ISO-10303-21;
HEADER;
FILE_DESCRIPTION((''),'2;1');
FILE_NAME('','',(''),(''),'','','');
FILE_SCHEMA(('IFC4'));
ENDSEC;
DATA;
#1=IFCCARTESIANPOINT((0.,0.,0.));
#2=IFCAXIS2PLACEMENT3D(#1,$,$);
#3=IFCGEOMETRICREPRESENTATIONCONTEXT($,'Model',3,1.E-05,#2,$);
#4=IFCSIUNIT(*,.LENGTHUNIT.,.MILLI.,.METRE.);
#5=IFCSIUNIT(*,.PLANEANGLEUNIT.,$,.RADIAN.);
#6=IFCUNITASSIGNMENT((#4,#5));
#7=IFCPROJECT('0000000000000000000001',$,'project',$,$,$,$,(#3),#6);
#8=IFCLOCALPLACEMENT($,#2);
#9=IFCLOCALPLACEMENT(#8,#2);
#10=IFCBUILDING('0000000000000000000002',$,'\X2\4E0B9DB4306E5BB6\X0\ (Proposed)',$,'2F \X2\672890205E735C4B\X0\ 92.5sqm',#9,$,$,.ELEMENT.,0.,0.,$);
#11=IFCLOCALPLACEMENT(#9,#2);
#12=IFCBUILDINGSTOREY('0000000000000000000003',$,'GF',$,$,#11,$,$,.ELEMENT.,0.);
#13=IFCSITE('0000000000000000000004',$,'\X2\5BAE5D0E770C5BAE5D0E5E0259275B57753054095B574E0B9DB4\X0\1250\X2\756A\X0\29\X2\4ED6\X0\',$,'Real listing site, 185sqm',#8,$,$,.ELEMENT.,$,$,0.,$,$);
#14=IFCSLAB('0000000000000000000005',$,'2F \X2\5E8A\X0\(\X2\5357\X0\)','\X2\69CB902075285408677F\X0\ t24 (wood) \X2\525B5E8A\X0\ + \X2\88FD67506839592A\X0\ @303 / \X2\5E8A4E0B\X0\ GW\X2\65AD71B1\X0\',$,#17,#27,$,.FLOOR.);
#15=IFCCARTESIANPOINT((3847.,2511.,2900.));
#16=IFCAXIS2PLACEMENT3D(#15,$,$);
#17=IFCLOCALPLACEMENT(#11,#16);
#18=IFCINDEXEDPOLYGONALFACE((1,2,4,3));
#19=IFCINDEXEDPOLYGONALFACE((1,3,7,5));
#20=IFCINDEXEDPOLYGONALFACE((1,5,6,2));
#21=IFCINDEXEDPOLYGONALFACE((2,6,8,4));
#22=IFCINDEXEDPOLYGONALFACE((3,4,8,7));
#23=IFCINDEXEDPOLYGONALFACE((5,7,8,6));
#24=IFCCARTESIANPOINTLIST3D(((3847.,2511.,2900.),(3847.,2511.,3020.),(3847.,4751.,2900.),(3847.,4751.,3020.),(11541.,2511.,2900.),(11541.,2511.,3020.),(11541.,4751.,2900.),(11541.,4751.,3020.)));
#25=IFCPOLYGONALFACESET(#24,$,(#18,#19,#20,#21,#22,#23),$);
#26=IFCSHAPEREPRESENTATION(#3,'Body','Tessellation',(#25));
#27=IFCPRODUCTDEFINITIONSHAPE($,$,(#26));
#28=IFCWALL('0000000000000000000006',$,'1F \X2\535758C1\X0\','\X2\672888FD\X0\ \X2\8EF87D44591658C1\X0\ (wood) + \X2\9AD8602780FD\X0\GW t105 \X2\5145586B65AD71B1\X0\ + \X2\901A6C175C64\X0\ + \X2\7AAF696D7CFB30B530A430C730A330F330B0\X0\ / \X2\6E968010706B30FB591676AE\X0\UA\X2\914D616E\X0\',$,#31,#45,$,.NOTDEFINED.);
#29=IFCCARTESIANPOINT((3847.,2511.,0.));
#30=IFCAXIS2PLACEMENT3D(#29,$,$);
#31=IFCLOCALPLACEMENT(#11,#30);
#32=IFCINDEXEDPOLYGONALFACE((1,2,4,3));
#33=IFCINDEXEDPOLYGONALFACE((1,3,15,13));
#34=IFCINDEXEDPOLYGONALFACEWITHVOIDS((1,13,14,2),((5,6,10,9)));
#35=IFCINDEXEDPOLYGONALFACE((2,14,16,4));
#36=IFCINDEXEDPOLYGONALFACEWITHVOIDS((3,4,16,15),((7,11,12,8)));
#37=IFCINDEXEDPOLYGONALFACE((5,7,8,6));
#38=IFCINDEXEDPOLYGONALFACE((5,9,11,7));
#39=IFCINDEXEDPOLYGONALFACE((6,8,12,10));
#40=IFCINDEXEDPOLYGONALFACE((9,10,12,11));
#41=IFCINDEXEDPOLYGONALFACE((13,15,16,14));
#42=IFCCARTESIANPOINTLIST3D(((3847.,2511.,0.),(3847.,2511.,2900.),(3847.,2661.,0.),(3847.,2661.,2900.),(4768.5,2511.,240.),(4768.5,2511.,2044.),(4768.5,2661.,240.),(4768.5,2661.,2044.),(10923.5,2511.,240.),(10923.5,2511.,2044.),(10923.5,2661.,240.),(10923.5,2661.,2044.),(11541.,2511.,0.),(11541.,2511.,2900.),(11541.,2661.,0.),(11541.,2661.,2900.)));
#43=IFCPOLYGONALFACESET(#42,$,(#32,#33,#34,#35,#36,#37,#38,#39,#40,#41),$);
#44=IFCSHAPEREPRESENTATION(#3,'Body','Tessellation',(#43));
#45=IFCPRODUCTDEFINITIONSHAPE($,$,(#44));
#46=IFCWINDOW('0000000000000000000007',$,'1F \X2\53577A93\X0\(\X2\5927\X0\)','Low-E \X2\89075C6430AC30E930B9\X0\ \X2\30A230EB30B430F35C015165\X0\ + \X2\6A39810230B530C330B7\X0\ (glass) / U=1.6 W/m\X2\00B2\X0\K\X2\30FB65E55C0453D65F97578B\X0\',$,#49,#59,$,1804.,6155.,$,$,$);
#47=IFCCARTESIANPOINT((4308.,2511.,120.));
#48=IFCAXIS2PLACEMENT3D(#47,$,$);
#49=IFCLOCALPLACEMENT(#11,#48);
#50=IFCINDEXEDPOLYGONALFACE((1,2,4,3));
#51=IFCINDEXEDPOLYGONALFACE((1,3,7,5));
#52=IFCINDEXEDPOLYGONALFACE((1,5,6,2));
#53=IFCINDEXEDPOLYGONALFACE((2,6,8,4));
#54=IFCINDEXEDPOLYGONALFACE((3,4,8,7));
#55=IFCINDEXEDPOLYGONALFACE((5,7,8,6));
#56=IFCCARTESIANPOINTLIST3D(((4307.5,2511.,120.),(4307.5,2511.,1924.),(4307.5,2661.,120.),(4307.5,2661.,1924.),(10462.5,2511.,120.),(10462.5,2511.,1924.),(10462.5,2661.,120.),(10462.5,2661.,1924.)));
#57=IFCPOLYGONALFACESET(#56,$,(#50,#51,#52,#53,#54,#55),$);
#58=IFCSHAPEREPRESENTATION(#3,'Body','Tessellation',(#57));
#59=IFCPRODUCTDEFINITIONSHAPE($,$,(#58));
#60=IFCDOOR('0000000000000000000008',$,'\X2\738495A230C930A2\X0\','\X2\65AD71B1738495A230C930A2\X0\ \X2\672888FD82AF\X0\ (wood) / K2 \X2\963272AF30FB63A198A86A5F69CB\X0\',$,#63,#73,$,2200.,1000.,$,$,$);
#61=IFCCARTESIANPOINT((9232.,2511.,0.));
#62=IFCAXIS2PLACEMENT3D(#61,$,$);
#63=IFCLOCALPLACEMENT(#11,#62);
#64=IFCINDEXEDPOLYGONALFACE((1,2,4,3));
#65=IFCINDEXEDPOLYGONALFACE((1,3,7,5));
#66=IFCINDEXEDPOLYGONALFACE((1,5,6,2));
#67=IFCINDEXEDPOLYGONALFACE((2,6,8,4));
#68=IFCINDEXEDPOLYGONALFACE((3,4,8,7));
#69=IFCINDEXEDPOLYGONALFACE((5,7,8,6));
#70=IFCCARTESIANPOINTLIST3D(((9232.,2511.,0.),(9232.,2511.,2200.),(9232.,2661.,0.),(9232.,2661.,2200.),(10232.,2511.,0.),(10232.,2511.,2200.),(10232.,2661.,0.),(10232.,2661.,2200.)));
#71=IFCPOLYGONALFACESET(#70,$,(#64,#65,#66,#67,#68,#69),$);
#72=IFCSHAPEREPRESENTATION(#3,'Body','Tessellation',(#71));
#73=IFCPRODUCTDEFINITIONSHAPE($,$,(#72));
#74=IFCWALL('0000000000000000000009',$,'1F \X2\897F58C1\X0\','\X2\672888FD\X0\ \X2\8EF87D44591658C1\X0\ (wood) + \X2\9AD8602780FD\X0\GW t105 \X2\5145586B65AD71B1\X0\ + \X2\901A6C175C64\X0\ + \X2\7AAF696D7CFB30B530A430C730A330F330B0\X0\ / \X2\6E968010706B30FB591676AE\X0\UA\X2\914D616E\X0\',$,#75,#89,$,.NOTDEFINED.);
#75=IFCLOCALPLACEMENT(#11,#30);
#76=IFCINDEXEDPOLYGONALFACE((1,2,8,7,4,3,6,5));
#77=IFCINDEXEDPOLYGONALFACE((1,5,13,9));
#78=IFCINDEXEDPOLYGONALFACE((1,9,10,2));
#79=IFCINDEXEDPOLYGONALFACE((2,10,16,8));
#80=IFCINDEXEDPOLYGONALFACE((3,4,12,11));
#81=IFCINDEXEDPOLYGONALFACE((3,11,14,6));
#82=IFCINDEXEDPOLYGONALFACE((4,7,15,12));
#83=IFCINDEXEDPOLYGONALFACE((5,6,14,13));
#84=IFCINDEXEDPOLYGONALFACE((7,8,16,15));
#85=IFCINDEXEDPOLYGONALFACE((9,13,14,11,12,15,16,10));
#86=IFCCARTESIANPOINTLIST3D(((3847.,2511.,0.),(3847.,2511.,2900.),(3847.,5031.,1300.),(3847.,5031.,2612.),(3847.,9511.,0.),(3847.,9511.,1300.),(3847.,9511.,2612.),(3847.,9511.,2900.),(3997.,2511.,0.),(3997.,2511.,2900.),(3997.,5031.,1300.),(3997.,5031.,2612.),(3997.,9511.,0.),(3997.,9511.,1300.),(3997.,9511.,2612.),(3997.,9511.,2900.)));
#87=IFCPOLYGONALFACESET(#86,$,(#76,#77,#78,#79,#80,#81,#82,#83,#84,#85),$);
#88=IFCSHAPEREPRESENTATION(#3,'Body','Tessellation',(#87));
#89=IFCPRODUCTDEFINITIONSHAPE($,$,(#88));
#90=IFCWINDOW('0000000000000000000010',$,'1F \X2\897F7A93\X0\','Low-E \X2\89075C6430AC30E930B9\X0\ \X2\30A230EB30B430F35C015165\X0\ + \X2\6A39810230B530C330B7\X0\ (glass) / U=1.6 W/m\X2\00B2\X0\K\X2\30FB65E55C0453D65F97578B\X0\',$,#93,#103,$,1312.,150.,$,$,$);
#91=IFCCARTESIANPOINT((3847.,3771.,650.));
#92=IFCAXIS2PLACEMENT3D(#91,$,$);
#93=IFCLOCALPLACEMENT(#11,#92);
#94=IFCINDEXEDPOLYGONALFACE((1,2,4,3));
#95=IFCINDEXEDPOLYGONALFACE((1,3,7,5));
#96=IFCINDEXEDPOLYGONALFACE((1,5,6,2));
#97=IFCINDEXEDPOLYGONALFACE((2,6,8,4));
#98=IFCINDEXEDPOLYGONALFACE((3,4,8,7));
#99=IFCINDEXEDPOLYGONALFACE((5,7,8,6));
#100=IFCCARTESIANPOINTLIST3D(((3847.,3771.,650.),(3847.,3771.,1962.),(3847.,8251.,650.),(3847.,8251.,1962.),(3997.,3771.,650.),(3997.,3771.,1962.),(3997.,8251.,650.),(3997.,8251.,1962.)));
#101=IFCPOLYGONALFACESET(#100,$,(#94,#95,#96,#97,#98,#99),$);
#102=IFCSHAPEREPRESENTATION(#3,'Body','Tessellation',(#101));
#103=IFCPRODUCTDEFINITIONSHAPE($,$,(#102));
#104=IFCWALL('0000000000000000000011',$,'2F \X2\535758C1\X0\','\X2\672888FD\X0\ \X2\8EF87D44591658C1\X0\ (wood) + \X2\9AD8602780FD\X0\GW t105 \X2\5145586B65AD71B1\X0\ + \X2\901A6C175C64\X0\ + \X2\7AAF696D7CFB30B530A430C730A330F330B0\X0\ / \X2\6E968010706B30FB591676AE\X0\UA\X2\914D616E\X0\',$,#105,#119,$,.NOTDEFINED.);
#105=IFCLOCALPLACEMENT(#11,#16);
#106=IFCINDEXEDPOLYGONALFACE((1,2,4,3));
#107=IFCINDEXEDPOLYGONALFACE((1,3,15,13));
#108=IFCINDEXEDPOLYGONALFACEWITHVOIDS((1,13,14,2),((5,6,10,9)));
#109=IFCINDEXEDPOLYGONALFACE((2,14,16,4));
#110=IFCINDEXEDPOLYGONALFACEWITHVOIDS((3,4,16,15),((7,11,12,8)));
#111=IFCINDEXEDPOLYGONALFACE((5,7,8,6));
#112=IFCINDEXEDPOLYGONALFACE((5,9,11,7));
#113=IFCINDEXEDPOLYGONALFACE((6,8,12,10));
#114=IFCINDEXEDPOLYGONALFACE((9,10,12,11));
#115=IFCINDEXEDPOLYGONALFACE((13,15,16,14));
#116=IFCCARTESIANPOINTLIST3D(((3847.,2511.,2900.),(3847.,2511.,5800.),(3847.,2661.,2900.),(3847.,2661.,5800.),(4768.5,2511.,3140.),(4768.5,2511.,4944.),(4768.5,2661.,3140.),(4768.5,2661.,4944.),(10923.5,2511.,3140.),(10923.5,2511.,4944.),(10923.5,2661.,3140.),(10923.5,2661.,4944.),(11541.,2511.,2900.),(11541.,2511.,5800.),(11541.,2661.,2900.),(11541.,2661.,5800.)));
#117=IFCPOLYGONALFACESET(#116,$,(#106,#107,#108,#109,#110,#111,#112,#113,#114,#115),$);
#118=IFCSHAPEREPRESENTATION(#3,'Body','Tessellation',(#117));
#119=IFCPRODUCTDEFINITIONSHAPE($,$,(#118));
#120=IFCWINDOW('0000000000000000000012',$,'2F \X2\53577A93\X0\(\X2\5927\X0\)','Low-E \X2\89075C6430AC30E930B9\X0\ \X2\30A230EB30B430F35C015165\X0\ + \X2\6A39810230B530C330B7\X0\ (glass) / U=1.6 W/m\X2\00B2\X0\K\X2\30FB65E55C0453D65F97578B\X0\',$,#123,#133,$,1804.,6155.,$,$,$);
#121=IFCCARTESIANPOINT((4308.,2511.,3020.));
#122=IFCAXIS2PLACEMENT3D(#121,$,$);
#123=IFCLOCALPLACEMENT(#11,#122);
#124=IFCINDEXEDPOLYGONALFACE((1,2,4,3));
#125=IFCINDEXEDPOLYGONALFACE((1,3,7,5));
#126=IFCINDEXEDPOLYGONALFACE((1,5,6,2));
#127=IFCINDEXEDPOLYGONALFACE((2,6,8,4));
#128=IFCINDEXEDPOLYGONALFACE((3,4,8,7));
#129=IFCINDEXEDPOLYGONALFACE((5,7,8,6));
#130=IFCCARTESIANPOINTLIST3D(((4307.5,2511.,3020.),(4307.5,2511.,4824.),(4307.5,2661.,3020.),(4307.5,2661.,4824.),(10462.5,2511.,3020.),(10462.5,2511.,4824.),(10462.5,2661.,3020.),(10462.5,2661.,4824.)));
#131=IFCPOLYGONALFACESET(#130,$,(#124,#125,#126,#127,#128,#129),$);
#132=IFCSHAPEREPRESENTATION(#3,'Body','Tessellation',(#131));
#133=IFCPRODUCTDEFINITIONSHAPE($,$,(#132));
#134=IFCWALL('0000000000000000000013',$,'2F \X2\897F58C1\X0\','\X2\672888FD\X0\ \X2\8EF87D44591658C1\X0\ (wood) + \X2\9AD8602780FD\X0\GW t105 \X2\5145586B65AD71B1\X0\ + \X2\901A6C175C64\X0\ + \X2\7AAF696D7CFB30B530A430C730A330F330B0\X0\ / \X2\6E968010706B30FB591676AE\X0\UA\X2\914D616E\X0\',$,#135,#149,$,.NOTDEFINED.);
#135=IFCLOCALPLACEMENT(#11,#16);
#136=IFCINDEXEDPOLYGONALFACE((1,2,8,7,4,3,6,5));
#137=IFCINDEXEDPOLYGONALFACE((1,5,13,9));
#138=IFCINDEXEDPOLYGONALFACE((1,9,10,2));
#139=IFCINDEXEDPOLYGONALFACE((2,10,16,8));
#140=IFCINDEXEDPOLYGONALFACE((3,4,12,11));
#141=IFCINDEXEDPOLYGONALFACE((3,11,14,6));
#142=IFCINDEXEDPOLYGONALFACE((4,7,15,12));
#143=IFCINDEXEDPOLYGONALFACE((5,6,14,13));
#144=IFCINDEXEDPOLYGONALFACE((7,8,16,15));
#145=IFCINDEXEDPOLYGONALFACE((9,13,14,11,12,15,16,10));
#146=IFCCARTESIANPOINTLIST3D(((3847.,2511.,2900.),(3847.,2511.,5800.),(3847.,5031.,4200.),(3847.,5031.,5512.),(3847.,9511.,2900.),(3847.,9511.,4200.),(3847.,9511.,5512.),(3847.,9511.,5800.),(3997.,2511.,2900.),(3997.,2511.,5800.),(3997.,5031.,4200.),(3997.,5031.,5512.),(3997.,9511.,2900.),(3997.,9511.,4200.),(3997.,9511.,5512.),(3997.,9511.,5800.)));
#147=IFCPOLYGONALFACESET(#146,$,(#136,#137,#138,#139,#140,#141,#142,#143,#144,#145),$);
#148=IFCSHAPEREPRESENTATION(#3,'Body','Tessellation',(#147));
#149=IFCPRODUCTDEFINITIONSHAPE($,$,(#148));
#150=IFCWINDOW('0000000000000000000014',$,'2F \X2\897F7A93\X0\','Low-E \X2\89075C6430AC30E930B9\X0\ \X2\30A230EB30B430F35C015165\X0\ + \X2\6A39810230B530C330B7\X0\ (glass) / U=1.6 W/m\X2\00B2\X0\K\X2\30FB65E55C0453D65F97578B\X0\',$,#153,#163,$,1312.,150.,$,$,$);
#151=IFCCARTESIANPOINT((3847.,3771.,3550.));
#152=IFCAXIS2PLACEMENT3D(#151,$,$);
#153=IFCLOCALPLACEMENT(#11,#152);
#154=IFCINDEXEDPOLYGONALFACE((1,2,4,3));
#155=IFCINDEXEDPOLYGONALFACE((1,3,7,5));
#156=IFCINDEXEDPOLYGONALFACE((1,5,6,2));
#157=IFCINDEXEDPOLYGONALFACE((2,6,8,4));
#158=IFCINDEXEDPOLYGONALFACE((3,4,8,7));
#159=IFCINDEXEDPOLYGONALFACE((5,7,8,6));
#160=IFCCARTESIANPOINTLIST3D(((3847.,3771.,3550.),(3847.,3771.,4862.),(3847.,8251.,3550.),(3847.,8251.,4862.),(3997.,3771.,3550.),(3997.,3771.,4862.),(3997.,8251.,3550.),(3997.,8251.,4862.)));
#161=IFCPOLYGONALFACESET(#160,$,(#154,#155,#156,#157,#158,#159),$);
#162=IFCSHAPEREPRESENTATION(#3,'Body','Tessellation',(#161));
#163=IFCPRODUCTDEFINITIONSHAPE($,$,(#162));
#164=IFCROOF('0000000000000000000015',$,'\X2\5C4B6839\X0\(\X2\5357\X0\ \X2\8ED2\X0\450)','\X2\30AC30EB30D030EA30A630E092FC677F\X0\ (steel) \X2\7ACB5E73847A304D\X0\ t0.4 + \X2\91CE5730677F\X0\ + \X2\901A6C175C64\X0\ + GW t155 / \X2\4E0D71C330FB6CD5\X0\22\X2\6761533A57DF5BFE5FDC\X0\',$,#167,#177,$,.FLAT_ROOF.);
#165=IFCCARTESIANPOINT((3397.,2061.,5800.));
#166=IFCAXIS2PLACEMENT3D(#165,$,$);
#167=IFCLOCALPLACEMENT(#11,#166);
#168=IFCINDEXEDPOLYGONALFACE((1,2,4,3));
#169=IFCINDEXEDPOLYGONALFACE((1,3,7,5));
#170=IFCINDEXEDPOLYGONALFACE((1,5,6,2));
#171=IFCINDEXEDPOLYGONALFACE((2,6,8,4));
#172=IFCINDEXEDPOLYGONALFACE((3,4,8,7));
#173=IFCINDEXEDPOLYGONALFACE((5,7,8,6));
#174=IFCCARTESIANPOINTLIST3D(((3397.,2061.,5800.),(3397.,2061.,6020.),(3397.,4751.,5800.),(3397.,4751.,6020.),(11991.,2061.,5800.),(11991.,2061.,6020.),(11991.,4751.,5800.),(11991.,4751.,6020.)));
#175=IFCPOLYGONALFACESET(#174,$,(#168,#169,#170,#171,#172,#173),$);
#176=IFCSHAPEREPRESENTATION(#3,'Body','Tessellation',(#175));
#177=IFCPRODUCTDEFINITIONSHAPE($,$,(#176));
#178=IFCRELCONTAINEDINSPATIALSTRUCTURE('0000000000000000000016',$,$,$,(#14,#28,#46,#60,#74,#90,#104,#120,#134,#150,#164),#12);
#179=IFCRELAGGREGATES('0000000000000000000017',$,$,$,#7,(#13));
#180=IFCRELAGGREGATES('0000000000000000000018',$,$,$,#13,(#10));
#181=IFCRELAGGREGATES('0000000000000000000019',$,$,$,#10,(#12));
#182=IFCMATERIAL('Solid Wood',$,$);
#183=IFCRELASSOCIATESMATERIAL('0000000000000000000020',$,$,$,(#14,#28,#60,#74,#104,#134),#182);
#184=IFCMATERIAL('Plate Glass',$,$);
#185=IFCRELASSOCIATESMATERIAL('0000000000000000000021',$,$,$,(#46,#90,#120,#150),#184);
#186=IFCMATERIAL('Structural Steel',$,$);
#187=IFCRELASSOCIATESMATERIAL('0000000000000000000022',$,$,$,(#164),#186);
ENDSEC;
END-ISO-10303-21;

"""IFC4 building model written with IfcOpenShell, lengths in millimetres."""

from ifc_helpers import new_model, si_unit, frame, frame_2d, origin, place, context, project, spatial, rectangle, extrude, material, element, fill, save


model = new_model("IFC4")

# Units and contexts
model_context = context("Model", 3, precision=1e-05, world=origin())
ifc_project = project(units=[si_unit("LENGTHUNIT", "METRE", prefix="MILLI"), si_unit("PLANEANGLEUNIT", "RADIAN")], contexts=[model_context])

# Site, building, storey
site_placement = place(None, origin())
site = spatial("IfcSite", under=ifc_project, at=site_placement, Name="宮崎県宮崎市大字田吉字下鶴1250番29他", ObjectType="Real listing site, 185sqm", CompositionType="ELEMENT", RefElevation=0.0)
building_placement = place(site_placement, origin())
building = spatial("IfcBuilding", under=site, at=building_placement, Name="下鶴の家 (Proposed)", ObjectType="2F 木造平屋 92.5sqm", CompositionType="ELEMENT", ElevationOfRefHeight=0.0, ElevationOfTerrain=0.0)
storey_placement = place(building_placement, origin())
storey = spatial("IfcBuildingStorey", under=building, at=storey_placement, Name="GF", CompositionType="ELEMENT", Elevation=0.0)

# Slab
ifc_material_1 = material(Name="Solid Wood")
slab_1_placement = place(storey_placement, frame((3847.0, 2511.0, 2900.0)))
element("IfcSlab", 1, at=slab_1_placement, inside=storey, material=ifc_material_1, Name="2F 床(南)", Description="構造用合板 t24 (wood) 剛床 + 製材根太 @303 / 床下 GW断熱", PredefinedType="FLOOR", context=model_context, shape_type="SweptSolid", body=[
    extrude(rectangle(XDim=7694.0, YDim=2240.0, at=frame_2d((3847.0, 1120.0))), frame((3847.0, 2511.0, 2900.0)), (0.0, 0.0, 1.0), 120.0),
])

# Wall, openings, window, door
wall_1_placement = place(storey_placement, frame((3847.0, 2511.0, 0.0)))
wall_1 = element("IfcWall", 2, at=wall_1_placement, inside=storey, material=ifc_material_1, Name="1F 南壁", Description="木製 軸組外壁 (wood) + 高性能GW t105 充填断熱 + 通気層 + 窯業系サイディング / 準耐火・外皮UA配慮", PredefinedType="NOTDEFINED", context=model_context, shape_type="SweptSolid", body=[
    extrude(rectangle(XDim=7694.0, YDim=150.0, at=frame_2d((3847.0, 75.0))), frame((3847.0, 2511.0, 0.0)), (0.0, 0.0, 1.0), 2900.0),
])
opening_1_placement = place(storey_placement, frame((4308.0, 2511.0, 120.0)))
opening_1 = element("IfcOpeningElement", 3, at=opening_1_placement, cuts=wall_1, PredefinedType="NOTDEFINED", context=model_context, shape_type="SweptSolid", body=[
    extrude(rectangle(XDim=6155.0, YDim=150.0, at=frame_2d((3077.0, 75.0))), frame((4308.0, 2511.0, 120.0)), (0.0, 0.0, 1.0), 1804.0),
])
opening_2_placement = place(storey_placement, frame((9232.0, 2511.0, 0.0)))
opening_2 = element("IfcOpeningElement", 4, at=opening_2_placement, cuts=wall_1, PredefinedType="NOTDEFINED", context=model_context, shape_type="SweptSolid", body=[
    extrude(rectangle(XDim=1000.0, YDim=150.0, at=frame_2d((500.0, 75.0))), frame((9232.0, 2511.0, 0.0)), (0.0, 0.0, 1.0), 2200.0),
])
ifc_material_2 = material(Name="Plate Glass")
window_1_placement = place(storey_placement, frame((4308.0, 2511.0, 120.0)))
window_1 = element("IfcWindow", 5, at=window_1_placement, inside=storey, material=ifc_material_2, Name="1F 南窓(大)", Description="Low-E 複層ガラス アルゴン封入 + 樹脂サッシ (glass) / U=1.6 W/m²K・日射取得型", OverallHeight=1804.0, OverallWidth=6155.0, context=model_context, shape_type="SweptSolid", body=[
    extrude(rectangle(XDim=6155.0, YDim=150.0, at=frame_2d((3077.0, 75.0))), frame((4308.0, 2511.0, 120.0)), (0.0, 0.0, 1.0), 1804.0),
])
fill(opening_1, window_1)
door_placement = place(storey_placement, frame((9232.0, 2511.0, 0.0)))
door = element("IfcDoor", 6, at=door_placement, inside=storey, material=ifc_material_1, Name="玄関ドア", Description="断熱玄関ドア 木製芯 (wood) / K2 防犯・採風機構", OverallHeight=2200.0, OverallWidth=1000.0, context=model_context, shape_type="SweptSolid", body=[
    extrude(rectangle(XDim=1000.0, YDim=150.0, at=frame_2d((500.0, 75.0))), frame((9232.0, 2511.0, 0.0)), (0.0, 0.0, 1.0), 2200.0),
])
fill(opening_2, door)

# Walls, openings, windows
wall_2_placement = place(storey_placement, frame((3847.0, 2511.0, 0.0)))
wall_2 = element("IfcWall", 7, at=wall_2_placement, inside=storey, material=ifc_material_1, Name="1F 西壁", Description="木製 軸組外壁 (wood) + 高性能GW t105 充填断熱 + 通気層 + 窯業系サイディング / 準耐火・外皮UA配慮", PredefinedType="NOTDEFINED", context=model_context, shape_type="SweptSolid", body=[
    extrude(rectangle(XDim=150.0, YDim=7000.0, at=frame_2d((75.0, 3500.0))), frame((3847.0, 2511.0, 0.0)), (0.0, 0.0, 1.0), 2900.0),
])
opening_3_placement = place(storey_placement, frame((3847.0, 3771.0, 650.0)))
opening_3 = element("IfcOpeningElement", 8, at=opening_3_placement, cuts=wall_2, PredefinedType="NOTDEFINED", context=model_context, shape_type="SweptSolid", body=[
    extrude(rectangle(XDim=150.0, YDim=4480.0, at=frame_2d((75.0, 2240.0))), frame((3847.0, 3771.0, 650.0)), (0.0, 0.0, 1.0), 1312.0),
])
window_2_placement = place(storey_placement, frame((3847.0, 3771.0, 650.0)))
window_2 = element("IfcWindow", 9, at=window_2_placement, inside=storey, material=ifc_material_2, Name="1F 西窓", Description="Low-E 複層ガラス アルゴン封入 + 樹脂サッシ (glass) / U=1.6 W/m²K・日射取得型", OverallHeight=1312.0, OverallWidth=150.0, context=model_context, shape_type="SweptSolid", body=[
    extrude(rectangle(XDim=150.0, YDim=4480.0, at=frame_2d((75.0, 2240.0))), frame((3847.0, 3771.0, 650.0)), (0.0, 0.0, 1.0), 1312.0),
])
fill(opening_3, window_2)
wall_3_placement = place(storey_placement, frame((3847.0, 2511.0, 2900.0)))
wall_3 = element("IfcWall", 10, at=wall_3_placement, inside=storey, material=ifc_material_1, Name="2F 南壁", Description="木製 軸組外壁 (wood) + 高性能GW t105 充填断熱 + 通気層 + 窯業系サイディング / 準耐火・外皮UA配慮", PredefinedType="NOTDEFINED", context=model_context, shape_type="SweptSolid", body=[
    extrude(rectangle(XDim=7694.0, YDim=150.0, at=frame_2d((3847.0, 75.0))), frame((3847.0, 2511.0, 2900.0)), (0.0, 0.0, 1.0), 2900.0),
])
opening_4_placement = place(storey_placement, frame((4308.0, 2511.0, 3020.0)))
opening_4 = element("IfcOpeningElement", 11, at=opening_4_placement, cuts=wall_3, PredefinedType="NOTDEFINED", context=model_context, shape_type="SweptSolid", body=[
    extrude(rectangle(XDim=6155.0, YDim=150.0, at=frame_2d((3077.0, 75.0))), frame((4308.0, 2511.0, 3020.0)), (0.0, 0.0, 1.0), 1804.0),
])
window_3_placement = place(storey_placement, frame((4308.0, 2511.0, 3020.0)))
window_3 = element("IfcWindow", 12, at=window_3_placement, inside=storey, material=ifc_material_2, Name="2F 南窓(大)", Description="Low-E 複層ガラス アルゴン封入 + 樹脂サッシ (glass) / U=1.6 W/m²K・日射取得型", OverallHeight=1804.0, OverallWidth=6155.0, context=model_context, shape_type="SweptSolid", body=[
    extrude(rectangle(XDim=6155.0, YDim=150.0, at=frame_2d((3077.0, 75.0))), frame((4308.0, 2511.0, 3020.0)), (0.0, 0.0, 1.0), 1804.0),
])
fill(opening_4, window_3)
wall_4_placement = place(storey_placement, frame((3847.0, 2511.0, 2900.0)))
wall_4 = element("IfcWall", 13, at=wall_4_placement, inside=storey, material=ifc_material_1, Name="2F 西壁", Description="木製 軸組外壁 (wood) + 高性能GW t105 充填断熱 + 通気層 + 窯業系サイディング / 準耐火・外皮UA配慮", PredefinedType="NOTDEFINED", context=model_context, shape_type="SweptSolid", body=[
    extrude(rectangle(XDim=150.0, YDim=7000.0, at=frame_2d((75.0, 3500.0))), frame((3847.0, 2511.0, 2900.0)), (0.0, 0.0, 1.0), 2900.0),
])
opening_5_placement = place(storey_placement, frame((3847.0, 3771.0, 3550.0)))
opening_5 = element("IfcOpeningElement", 14, at=opening_5_placement, cuts=wall_4, PredefinedType="NOTDEFINED", context=model_context, shape_type="SweptSolid", body=[
    extrude(rectangle(XDim=150.0, YDim=4480.0, at=frame_2d((75.0, 2240.0))), frame((3847.0, 3771.0, 3550.0)), (0.0, 0.0, 1.0), 1312.0),
])
window_4_placement = place(storey_placement, frame((3847.0, 3771.0, 3550.0)))
window_4 = element("IfcWindow", 15, at=window_4_placement, inside=storey, material=ifc_material_2, Name="2F 西窓", Description="Low-E 複層ガラス アルゴン封入 + 樹脂サッシ (glass) / U=1.6 W/m²K・日射取得型", OverallHeight=1312.0, OverallWidth=150.0, context=model_context, shape_type="SweptSolid", body=[
    extrude(rectangle(XDim=150.0, YDim=4480.0, at=frame_2d((75.0, 2240.0))), frame((3847.0, 3771.0, 3550.0)), (0.0, 0.0, 1.0), 1312.0),
])
fill(opening_5, window_4)

# Roof
ifc_material_3 = material(Name="Structural Steel")
roof_1_placement = place(storey_placement, frame((3397.0, 2061.0, 5800.0)))
element("IfcRoof", 16, at=roof_1_placement, inside=storey, material=ifc_material_3, Name="屋根(南 軒450)", Description="ガルバリウム鋼板 (steel) 立平葺き t0.4 + 野地板 + 通気層 + GW t155 / 不燃・法22条区域対応", PredefinedType="FLAT_ROOF", context=model_context, shape_type="SweptSolid", body=[
    extrude(rectangle(XDim=8594.0, YDim=2690.0, at=frame_2d((4297.0, 1345.0))), frame((3397.0, 2061.0, 5800.0)), (0.0, 0.0, 1.0), 220.0),
])

save(model, "model.ifc")
